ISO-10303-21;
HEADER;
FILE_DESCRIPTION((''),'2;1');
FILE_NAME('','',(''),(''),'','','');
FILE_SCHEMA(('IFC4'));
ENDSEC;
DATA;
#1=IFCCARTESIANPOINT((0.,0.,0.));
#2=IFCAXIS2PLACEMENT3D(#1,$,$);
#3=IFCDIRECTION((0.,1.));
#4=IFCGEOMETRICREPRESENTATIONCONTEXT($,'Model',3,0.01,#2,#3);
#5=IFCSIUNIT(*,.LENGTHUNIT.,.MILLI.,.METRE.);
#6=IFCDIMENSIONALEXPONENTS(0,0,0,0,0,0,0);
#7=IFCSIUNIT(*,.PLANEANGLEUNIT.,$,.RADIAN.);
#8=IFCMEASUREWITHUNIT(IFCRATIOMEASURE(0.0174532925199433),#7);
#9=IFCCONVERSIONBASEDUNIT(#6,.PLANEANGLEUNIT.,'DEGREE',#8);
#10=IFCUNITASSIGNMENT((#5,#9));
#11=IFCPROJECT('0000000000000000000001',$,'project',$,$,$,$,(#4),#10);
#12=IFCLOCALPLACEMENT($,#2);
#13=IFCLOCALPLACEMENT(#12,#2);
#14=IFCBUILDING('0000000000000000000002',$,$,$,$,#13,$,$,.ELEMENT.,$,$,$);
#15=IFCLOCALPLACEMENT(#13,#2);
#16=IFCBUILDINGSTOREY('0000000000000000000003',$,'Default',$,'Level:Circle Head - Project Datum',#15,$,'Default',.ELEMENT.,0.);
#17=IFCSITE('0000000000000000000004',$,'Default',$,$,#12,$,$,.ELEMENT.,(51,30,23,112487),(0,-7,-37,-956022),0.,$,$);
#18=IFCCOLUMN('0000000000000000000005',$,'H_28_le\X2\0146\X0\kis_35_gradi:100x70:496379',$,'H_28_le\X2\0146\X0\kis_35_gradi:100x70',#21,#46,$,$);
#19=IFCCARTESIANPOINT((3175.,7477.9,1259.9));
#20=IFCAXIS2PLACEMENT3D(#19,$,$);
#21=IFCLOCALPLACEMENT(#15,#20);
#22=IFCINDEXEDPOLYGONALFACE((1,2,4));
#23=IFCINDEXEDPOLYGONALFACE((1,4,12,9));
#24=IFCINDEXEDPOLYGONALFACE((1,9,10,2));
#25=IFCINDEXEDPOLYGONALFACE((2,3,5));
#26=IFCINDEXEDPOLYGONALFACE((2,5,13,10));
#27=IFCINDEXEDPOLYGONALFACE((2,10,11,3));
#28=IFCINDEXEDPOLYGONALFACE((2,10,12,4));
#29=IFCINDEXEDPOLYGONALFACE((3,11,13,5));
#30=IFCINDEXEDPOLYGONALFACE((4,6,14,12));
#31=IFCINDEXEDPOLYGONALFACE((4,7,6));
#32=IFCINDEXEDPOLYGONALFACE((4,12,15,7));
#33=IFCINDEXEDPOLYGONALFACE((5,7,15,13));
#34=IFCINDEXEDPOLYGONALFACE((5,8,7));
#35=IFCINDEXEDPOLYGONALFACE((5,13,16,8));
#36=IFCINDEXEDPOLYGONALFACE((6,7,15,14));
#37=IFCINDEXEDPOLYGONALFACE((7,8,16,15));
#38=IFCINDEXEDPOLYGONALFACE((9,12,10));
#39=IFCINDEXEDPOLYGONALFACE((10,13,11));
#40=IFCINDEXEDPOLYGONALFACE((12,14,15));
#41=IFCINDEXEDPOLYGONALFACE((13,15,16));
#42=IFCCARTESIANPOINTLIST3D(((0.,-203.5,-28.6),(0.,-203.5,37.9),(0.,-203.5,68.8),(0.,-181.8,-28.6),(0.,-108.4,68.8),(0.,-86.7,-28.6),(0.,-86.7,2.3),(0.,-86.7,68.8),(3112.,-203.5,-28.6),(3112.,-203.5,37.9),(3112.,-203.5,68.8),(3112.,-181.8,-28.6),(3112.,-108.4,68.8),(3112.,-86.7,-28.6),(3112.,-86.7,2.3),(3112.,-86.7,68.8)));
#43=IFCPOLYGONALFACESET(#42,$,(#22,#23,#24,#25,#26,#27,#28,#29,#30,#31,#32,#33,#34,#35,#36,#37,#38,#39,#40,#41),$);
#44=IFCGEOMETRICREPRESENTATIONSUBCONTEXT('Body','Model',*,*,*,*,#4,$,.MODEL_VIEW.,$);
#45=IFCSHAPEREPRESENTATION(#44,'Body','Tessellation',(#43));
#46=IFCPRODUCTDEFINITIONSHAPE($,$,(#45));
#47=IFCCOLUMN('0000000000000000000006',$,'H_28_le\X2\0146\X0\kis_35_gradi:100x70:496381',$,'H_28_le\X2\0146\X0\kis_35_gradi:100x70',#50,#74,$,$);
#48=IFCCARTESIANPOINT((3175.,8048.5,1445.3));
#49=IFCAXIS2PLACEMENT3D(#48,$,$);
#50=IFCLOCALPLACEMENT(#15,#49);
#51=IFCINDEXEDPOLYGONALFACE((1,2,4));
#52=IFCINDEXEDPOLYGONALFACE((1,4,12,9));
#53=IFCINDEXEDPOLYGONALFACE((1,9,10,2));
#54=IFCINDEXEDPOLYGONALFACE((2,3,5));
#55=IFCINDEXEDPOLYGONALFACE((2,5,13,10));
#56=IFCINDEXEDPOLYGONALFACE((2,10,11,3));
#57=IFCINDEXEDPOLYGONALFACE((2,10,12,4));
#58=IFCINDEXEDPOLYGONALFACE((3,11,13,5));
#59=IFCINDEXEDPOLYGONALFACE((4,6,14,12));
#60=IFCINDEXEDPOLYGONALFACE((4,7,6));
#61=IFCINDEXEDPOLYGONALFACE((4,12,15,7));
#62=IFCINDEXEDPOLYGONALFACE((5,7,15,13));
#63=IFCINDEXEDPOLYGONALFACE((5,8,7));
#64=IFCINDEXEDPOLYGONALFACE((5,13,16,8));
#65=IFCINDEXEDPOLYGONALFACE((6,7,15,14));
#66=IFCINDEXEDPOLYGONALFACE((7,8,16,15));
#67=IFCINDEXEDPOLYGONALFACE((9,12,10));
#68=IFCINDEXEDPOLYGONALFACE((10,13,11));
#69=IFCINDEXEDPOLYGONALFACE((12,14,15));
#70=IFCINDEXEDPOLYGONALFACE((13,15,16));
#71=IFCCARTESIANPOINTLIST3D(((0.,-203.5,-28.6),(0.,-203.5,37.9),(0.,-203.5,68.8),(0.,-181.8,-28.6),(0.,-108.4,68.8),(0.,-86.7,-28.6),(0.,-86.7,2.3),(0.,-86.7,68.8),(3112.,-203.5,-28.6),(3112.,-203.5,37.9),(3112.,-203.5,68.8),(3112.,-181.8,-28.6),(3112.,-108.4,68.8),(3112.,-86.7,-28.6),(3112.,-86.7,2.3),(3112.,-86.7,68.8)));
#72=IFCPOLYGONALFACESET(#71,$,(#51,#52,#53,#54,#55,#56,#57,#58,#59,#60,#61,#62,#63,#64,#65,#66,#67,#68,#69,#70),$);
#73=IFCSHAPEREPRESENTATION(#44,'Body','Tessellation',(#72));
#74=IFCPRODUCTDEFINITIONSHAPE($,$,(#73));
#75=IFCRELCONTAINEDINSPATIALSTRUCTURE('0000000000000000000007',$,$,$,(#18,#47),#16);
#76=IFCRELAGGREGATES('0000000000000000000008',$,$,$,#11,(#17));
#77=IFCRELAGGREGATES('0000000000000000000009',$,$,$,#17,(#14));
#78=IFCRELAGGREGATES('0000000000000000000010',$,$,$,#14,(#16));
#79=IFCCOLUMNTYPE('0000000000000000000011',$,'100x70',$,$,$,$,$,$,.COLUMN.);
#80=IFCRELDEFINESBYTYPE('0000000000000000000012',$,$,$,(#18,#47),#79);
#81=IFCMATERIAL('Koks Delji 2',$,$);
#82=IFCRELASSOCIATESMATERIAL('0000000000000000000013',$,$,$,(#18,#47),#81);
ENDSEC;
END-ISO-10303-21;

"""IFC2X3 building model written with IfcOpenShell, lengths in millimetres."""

from ifc_helpers import new_model, entity, si_unit, converted_unit, direction, frame, frame_2d, origin, origin_2d_with_axis, place, context, subcontext, project, spatial, rectangle, extrude, boolean, source, transform, mapped, material, type_object, type_shapes, element, save


model = new_model("IFC2X3")

# Units and contexts
model_context = context("Model", 3, precision=0.01, world=origin(), true_north=direction((0.0, 1.0)))
body_context = subcontext(model_context, "Body", "Model", "MODEL_VIEW")
ifc_project = project(units=[si_unit("LENGTHUNIT", "METRE", prefix="MILLI"), converted_unit("PLANEANGLEUNIT", "DEGREE", entity("IfcRatioMeasure", 0.0174532925199433), si_unit("PLANEANGLEUNIT", "RADIAN"), dimensions=[0, 0, 0, 0, 0, 0, 0])], contexts=[model_context])

# Site, building, storey
site_placement = place(None, origin())
site = spatial("IfcSite", under=ifc_project, at=site_placement, Name="Default", CompositionType="ELEMENT", RefLatitude=(51, 30, 23, 112487), RefLongitude=(0, -7, -37, -956022), RefElevation=0.0)
building_placement = place(site_placement, origin())
building = spatial("IfcBuilding", under=site, at=building_placement, CompositionType="ELEMENT")
storey_placement = place(building_placement, origin())
storey = spatial("IfcBuildingStorey", under=building, at=storey_placement, Name="Default", ObjectType="Level:Circle Head - Project Datum", LongName="Default", CompositionType="ELEMENT", Elevation=0.0)

# Columns
ifc_material_1 = material(Name="Koks Delji 2")
column_type_1 = type_object("IfcColumnType", Name="100x70", PredefinedType="COLUMN")
shared_shape_1 = source(origin(), body_context, "Body", "CSG", [
    boolean("DIFFERENCE", extrude(rectangle(XDim=3112.0, YDim=116.7, at=origin_2d_with_axis()), frame((1556.0, -145.1, -28.6)), (0.0, 0.0, 1.0), 97.5), extrude(rectangle(XDim=70.0, YDim=100.0, at=frame_2d((0.0, 0.0), x_axis=(0.0, 1.0))), frame((0.0, -145.1, 20.1), z_axis=(-1.0, 0.0, 0.0), x_axis=(0.0, -0.951057, -0.309017)), (0.0, 0.0, -1.0), 3112.0)),
])
type_shapes(column_type_1, [shared_shape_1])
for number, where, name in (
    (1, (3175.0, 7477.9, 1259.9), "H_28_leņkis_35_gradi:100x70:496379"),
    (2, (3175.0, 8048.5, 1445.3), "H_28_leņkis_35_gradi:100x70:496381"),
):
    element("IfcColumn", number, at=place(storey_placement, frame(where)), inside=storey, type_object=column_type_1, material=ifc_material_1, Name=name, ObjectType="H_28_leņkis_35_gradi:100x70", context=body_context, shape_type="MappedRepresentation", body=[
        mapped(shared_shape_1, transform((0.0, 0.0, 0.0), scale=1.0)),
    ])

save(model, "model.ifc")
